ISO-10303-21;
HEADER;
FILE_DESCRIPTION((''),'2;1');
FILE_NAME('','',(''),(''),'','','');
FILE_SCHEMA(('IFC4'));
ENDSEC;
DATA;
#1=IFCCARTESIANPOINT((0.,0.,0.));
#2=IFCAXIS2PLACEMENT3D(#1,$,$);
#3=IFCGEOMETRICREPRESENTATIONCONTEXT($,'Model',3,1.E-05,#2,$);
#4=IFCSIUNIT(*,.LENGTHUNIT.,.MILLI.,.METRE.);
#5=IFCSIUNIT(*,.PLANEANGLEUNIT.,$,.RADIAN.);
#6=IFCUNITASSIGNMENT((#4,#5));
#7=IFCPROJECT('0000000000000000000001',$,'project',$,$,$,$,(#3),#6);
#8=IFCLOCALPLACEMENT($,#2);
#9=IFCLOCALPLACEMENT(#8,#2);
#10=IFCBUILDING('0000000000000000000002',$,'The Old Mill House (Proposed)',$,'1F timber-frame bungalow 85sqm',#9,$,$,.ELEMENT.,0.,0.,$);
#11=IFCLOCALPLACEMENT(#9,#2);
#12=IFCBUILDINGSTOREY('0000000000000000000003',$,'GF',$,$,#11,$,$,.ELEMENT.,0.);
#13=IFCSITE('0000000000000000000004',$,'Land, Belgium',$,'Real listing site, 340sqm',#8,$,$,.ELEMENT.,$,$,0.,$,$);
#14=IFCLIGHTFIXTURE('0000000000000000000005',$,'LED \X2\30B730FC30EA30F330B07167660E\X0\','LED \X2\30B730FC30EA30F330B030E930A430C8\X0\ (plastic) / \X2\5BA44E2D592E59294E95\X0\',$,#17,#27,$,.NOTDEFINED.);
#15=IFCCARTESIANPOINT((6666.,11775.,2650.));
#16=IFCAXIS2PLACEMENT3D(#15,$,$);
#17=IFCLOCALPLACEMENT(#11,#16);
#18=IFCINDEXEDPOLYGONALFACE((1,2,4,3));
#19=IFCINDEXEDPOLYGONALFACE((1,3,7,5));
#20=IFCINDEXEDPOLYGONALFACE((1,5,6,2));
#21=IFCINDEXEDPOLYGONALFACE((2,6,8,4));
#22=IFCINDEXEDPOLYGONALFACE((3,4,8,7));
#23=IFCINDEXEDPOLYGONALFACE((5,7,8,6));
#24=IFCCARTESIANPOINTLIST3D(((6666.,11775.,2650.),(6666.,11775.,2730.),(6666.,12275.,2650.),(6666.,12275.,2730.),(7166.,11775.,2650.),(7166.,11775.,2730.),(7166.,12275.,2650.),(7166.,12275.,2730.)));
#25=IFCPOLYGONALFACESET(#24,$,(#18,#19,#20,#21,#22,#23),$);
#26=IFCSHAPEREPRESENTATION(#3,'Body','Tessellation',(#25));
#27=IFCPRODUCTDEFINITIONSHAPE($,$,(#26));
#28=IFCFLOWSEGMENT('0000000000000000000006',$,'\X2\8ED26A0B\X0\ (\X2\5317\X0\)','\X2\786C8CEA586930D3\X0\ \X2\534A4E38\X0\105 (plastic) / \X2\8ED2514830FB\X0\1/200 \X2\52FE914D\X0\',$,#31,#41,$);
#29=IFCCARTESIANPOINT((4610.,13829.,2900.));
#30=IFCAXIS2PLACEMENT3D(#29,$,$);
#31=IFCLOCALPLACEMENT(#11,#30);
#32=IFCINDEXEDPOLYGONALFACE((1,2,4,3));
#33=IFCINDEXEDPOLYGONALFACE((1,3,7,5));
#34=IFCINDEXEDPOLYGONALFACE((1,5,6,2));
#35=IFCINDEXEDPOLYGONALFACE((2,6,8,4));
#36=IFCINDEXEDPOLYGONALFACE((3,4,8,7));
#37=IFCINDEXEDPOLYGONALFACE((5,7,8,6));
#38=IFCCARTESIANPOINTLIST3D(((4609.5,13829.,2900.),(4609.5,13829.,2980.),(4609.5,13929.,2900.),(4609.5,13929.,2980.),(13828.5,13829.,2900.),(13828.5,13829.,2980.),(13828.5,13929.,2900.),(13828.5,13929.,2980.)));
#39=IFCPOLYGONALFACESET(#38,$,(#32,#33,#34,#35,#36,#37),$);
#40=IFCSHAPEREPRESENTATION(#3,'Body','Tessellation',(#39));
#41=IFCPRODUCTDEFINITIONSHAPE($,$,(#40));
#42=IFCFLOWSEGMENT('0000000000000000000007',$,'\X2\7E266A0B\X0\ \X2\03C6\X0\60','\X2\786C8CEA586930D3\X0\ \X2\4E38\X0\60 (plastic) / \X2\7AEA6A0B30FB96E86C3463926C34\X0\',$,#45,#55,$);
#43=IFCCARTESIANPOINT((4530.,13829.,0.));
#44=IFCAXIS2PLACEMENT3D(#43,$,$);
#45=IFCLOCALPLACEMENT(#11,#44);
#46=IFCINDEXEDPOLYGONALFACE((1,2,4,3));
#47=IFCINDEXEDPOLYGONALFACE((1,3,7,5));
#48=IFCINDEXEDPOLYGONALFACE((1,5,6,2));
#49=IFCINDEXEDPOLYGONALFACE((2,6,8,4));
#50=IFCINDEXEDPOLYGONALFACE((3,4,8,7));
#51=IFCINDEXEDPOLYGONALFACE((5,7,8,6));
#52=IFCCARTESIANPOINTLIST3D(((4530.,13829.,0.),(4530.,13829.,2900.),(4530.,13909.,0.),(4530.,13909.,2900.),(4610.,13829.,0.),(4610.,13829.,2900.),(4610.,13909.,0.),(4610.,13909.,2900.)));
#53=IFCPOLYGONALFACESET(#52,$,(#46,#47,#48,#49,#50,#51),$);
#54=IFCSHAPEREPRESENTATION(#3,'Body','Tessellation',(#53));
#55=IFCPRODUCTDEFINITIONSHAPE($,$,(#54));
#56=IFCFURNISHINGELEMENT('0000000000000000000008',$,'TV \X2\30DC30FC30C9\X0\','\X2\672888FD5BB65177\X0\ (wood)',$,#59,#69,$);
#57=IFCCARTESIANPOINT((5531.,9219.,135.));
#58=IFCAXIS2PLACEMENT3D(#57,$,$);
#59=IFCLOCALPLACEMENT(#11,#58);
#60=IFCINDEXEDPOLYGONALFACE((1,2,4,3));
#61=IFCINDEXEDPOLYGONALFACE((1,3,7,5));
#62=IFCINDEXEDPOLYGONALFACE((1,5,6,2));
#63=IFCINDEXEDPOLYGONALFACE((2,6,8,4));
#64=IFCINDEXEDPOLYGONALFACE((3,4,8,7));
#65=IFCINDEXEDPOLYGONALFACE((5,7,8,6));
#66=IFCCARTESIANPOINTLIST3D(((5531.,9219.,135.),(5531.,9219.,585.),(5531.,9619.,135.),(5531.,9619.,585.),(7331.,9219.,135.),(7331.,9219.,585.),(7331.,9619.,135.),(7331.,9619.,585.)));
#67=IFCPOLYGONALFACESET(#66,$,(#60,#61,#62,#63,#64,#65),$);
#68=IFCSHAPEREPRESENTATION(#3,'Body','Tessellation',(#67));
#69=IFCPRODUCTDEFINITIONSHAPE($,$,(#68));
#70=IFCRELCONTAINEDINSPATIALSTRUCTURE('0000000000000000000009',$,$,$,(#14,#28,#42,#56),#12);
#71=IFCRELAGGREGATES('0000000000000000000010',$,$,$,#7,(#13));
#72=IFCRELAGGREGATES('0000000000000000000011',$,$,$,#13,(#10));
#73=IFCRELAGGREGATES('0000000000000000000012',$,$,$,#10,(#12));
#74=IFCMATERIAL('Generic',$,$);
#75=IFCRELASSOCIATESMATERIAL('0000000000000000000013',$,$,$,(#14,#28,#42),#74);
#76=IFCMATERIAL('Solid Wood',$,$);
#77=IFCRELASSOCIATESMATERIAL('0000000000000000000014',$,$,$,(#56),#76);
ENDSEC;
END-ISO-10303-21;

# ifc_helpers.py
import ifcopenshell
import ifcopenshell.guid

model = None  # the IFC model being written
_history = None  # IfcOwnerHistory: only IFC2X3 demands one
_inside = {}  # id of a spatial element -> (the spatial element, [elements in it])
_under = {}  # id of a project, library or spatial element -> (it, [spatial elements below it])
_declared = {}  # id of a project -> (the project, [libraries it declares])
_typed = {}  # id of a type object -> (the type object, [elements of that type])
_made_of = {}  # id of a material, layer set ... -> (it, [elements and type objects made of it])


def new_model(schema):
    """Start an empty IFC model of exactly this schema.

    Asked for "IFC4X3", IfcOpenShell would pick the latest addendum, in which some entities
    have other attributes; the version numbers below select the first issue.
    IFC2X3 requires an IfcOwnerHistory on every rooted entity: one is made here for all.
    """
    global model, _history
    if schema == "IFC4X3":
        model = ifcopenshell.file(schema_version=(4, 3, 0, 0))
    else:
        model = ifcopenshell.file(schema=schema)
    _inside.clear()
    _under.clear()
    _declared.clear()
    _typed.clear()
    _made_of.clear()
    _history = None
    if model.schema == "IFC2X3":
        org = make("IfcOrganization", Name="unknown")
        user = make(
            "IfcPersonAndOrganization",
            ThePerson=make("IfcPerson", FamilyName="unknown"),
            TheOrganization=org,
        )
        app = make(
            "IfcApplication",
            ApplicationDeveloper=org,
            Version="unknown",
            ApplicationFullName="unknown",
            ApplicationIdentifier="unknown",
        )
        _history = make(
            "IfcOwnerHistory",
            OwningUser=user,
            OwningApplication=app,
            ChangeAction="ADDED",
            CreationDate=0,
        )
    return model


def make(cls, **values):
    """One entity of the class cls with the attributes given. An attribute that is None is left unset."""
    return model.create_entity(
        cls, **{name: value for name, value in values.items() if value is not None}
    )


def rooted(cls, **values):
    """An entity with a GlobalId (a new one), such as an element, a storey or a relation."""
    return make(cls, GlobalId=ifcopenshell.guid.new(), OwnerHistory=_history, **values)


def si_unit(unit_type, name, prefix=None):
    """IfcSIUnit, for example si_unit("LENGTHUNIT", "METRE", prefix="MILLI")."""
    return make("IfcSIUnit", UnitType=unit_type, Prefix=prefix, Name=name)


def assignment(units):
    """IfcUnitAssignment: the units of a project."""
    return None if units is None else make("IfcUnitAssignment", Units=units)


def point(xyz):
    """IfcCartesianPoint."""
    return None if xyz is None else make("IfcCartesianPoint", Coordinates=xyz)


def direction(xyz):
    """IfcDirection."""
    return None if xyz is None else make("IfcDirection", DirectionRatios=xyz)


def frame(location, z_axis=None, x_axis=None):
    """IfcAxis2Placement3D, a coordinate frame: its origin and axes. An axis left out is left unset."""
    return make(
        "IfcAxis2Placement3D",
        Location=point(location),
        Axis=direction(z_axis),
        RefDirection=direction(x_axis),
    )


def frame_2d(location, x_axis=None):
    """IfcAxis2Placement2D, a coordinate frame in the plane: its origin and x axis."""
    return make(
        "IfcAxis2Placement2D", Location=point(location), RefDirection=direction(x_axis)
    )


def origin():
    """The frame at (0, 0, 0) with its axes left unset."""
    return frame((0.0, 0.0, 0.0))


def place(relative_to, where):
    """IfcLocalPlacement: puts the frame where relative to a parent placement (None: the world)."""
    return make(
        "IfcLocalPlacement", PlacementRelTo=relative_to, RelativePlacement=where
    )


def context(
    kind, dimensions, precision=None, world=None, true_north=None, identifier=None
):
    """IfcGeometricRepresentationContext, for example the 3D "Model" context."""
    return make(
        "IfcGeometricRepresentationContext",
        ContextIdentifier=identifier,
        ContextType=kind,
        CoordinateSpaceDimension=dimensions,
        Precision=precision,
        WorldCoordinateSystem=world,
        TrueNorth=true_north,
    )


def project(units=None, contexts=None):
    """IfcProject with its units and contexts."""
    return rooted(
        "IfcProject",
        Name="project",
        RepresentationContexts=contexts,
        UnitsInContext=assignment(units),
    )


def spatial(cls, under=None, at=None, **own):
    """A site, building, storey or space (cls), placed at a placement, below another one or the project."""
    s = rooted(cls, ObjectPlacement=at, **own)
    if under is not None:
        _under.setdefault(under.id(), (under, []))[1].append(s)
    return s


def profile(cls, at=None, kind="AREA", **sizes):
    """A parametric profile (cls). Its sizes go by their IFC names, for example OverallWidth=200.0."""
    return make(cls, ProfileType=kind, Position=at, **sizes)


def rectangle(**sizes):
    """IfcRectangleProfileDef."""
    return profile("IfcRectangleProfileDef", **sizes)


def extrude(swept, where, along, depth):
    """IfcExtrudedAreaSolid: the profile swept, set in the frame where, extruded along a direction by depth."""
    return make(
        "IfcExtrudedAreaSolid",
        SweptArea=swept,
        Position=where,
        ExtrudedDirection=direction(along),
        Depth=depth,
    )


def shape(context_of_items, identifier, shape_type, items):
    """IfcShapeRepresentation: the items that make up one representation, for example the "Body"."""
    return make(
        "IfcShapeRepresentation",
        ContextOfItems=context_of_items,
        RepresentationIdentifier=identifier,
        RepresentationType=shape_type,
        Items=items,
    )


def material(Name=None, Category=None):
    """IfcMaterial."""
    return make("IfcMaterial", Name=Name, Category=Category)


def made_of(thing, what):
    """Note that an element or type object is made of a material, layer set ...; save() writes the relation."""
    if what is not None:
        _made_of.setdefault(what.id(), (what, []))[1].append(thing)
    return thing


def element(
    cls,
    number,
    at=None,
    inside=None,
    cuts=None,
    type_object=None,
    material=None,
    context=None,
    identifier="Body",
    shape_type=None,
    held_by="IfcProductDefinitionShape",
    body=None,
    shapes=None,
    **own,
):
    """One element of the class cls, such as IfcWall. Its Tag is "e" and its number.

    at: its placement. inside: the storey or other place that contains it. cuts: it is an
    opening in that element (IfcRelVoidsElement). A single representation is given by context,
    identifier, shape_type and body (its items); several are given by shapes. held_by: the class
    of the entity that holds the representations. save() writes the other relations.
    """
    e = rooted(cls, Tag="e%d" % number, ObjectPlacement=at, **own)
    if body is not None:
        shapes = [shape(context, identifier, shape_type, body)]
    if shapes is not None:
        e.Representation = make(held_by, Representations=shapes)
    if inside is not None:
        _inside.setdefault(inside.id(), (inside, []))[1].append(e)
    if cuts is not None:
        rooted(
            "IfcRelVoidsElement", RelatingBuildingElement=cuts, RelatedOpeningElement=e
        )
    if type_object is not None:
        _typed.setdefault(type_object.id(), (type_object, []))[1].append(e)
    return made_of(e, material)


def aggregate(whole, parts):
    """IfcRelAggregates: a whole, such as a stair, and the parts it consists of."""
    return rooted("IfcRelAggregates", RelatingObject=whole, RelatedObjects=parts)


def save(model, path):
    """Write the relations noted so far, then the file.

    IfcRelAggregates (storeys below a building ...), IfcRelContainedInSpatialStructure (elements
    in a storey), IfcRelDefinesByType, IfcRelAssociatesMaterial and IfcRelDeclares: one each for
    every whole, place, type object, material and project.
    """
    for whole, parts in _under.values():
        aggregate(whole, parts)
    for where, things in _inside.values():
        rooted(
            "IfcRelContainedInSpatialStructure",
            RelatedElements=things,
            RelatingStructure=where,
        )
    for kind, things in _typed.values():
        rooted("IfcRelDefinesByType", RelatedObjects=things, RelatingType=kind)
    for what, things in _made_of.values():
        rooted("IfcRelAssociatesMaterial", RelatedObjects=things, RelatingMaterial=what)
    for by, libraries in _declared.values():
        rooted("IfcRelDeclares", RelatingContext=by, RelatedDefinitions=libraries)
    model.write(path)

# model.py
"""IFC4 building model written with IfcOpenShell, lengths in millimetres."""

from ifc_helpers import new_model, si_unit, frame, frame_2d, origin, place, context, project, spatial, rectangle, extrude, material, element, save


model = new_model("IFC4")

# Units and contexts
model_context = context("Model", 3, precision=1e-05, world=origin())
ifc_project = project(units=[si_unit("LENGTHUNIT", "METRE", prefix="MILLI"), si_unit("PLANEANGLEUNIT", "RADIAN")], contexts=[model_context])

# Site, building, storey
site_placement = place(None, origin())
site = spatial("IfcSite", under=ifc_project, at=site_placement, Name="Land, Belgium", ObjectType="Real listing site, 340sqm", CompositionType="ELEMENT", RefElevation=0.0)
building_placement = place(site_placement, origin())
building = spatial("IfcBuilding", under=site, at=building_placement, Name="The Old Mill House (Proposed)", ObjectType="1F timber-frame bungalow 85sqm", CompositionType="ELEMENT", ElevationOfRefHeight=0.0, ElevationOfTerrain=0.0)
storey_placement = place(building_placement, origin())
storey = spatial("IfcBuildingStorey", under=building, at=storey_placement, Name="GF", CompositionType="ELEMENT", Elevation=0.0)

# Shared definitions
ifc_material_1 = material(Name="Solid Wood")

# Shared definitions
ifc_material_2 = material(Name="Generic")

# Light fixture
light_fixture_placement = place(storey_placement, frame((6666.0, 11775.0, 2650.0)))
element("IfcLightFixture", 1, at=light_fixture_placement, inside=storey, material=ifc_material_2, Name="LED シーリング照明", Description="LED シーリングライト (plastic) / 室中央天井", PredefinedType="NOTDEFINED", context=model_context, shape_type="SweptSolid", body=[
    extrude(rectangle(XDim=500.0, YDim=500.0, at=frame_2d((250.0, 250.0))), frame((6666.0, 11775.0, 2650.0)), (0.0, 0.0, 1.0), 80.0),
])

# Flow segments
flow_segment_1_placement = place(storey_placement, frame((4610.0, 13829.0, 2900.0)))
element("IfcFlowSegment", 2, at=flow_segment_1_placement, inside=storey, material=ifc_material_2, Name="軒樋 (北)", Description="硬質塩ビ 半丸105 (plastic) / 軒先・1/200 勾配", context=model_context, shape_type="SweptSolid", body=[
    extrude(rectangle(XDim=9219.0, YDim=100.0, at=frame_2d((4609.0, 50.0))), frame((4610.0, 13829.0, 2900.0)), (0.0, 0.0, 1.0), 80.0),
])
flow_segment_2_placement = place(storey_placement, frame((4530.0, 13829.0, 0.0)))
element("IfcFlowSegment", 3, at=flow_segment_2_placement, inside=storey, material=ifc_material_2, Name="縦樋 φ60", Description="硬質塩ビ 丸60 (plastic) / 竪樋・雨水排水", context=model_context, shape_type="SweptSolid", body=[
    extrude(rectangle(XDim=80.0, YDim=80.0, at=frame_2d((40.0, 40.0))), frame((4530.0, 13829.0, 0.0)), (0.0, 0.0, 1.0), 2900.0),
])

# Furnishing element
furnishing_placement = place(storey_placement, frame((5531.0, 9219.0, 135.0)))
element("IfcFurnishingElement", 4, at=furnishing_placement, inside=storey, material=ifc_material_1, Name="TV ボード", Description="木製家具 (wood)", context=model_context, shape_type="SweptSolid", body=[
    extrude(rectangle(XDim=1800.0, YDim=400.0, at=frame_2d((900.0, 200.0))), frame((5531.0, 9219.0, 135.0)), (0.0, 0.0, 1.0), 450.0),
])

save(model, "model.ifc")
